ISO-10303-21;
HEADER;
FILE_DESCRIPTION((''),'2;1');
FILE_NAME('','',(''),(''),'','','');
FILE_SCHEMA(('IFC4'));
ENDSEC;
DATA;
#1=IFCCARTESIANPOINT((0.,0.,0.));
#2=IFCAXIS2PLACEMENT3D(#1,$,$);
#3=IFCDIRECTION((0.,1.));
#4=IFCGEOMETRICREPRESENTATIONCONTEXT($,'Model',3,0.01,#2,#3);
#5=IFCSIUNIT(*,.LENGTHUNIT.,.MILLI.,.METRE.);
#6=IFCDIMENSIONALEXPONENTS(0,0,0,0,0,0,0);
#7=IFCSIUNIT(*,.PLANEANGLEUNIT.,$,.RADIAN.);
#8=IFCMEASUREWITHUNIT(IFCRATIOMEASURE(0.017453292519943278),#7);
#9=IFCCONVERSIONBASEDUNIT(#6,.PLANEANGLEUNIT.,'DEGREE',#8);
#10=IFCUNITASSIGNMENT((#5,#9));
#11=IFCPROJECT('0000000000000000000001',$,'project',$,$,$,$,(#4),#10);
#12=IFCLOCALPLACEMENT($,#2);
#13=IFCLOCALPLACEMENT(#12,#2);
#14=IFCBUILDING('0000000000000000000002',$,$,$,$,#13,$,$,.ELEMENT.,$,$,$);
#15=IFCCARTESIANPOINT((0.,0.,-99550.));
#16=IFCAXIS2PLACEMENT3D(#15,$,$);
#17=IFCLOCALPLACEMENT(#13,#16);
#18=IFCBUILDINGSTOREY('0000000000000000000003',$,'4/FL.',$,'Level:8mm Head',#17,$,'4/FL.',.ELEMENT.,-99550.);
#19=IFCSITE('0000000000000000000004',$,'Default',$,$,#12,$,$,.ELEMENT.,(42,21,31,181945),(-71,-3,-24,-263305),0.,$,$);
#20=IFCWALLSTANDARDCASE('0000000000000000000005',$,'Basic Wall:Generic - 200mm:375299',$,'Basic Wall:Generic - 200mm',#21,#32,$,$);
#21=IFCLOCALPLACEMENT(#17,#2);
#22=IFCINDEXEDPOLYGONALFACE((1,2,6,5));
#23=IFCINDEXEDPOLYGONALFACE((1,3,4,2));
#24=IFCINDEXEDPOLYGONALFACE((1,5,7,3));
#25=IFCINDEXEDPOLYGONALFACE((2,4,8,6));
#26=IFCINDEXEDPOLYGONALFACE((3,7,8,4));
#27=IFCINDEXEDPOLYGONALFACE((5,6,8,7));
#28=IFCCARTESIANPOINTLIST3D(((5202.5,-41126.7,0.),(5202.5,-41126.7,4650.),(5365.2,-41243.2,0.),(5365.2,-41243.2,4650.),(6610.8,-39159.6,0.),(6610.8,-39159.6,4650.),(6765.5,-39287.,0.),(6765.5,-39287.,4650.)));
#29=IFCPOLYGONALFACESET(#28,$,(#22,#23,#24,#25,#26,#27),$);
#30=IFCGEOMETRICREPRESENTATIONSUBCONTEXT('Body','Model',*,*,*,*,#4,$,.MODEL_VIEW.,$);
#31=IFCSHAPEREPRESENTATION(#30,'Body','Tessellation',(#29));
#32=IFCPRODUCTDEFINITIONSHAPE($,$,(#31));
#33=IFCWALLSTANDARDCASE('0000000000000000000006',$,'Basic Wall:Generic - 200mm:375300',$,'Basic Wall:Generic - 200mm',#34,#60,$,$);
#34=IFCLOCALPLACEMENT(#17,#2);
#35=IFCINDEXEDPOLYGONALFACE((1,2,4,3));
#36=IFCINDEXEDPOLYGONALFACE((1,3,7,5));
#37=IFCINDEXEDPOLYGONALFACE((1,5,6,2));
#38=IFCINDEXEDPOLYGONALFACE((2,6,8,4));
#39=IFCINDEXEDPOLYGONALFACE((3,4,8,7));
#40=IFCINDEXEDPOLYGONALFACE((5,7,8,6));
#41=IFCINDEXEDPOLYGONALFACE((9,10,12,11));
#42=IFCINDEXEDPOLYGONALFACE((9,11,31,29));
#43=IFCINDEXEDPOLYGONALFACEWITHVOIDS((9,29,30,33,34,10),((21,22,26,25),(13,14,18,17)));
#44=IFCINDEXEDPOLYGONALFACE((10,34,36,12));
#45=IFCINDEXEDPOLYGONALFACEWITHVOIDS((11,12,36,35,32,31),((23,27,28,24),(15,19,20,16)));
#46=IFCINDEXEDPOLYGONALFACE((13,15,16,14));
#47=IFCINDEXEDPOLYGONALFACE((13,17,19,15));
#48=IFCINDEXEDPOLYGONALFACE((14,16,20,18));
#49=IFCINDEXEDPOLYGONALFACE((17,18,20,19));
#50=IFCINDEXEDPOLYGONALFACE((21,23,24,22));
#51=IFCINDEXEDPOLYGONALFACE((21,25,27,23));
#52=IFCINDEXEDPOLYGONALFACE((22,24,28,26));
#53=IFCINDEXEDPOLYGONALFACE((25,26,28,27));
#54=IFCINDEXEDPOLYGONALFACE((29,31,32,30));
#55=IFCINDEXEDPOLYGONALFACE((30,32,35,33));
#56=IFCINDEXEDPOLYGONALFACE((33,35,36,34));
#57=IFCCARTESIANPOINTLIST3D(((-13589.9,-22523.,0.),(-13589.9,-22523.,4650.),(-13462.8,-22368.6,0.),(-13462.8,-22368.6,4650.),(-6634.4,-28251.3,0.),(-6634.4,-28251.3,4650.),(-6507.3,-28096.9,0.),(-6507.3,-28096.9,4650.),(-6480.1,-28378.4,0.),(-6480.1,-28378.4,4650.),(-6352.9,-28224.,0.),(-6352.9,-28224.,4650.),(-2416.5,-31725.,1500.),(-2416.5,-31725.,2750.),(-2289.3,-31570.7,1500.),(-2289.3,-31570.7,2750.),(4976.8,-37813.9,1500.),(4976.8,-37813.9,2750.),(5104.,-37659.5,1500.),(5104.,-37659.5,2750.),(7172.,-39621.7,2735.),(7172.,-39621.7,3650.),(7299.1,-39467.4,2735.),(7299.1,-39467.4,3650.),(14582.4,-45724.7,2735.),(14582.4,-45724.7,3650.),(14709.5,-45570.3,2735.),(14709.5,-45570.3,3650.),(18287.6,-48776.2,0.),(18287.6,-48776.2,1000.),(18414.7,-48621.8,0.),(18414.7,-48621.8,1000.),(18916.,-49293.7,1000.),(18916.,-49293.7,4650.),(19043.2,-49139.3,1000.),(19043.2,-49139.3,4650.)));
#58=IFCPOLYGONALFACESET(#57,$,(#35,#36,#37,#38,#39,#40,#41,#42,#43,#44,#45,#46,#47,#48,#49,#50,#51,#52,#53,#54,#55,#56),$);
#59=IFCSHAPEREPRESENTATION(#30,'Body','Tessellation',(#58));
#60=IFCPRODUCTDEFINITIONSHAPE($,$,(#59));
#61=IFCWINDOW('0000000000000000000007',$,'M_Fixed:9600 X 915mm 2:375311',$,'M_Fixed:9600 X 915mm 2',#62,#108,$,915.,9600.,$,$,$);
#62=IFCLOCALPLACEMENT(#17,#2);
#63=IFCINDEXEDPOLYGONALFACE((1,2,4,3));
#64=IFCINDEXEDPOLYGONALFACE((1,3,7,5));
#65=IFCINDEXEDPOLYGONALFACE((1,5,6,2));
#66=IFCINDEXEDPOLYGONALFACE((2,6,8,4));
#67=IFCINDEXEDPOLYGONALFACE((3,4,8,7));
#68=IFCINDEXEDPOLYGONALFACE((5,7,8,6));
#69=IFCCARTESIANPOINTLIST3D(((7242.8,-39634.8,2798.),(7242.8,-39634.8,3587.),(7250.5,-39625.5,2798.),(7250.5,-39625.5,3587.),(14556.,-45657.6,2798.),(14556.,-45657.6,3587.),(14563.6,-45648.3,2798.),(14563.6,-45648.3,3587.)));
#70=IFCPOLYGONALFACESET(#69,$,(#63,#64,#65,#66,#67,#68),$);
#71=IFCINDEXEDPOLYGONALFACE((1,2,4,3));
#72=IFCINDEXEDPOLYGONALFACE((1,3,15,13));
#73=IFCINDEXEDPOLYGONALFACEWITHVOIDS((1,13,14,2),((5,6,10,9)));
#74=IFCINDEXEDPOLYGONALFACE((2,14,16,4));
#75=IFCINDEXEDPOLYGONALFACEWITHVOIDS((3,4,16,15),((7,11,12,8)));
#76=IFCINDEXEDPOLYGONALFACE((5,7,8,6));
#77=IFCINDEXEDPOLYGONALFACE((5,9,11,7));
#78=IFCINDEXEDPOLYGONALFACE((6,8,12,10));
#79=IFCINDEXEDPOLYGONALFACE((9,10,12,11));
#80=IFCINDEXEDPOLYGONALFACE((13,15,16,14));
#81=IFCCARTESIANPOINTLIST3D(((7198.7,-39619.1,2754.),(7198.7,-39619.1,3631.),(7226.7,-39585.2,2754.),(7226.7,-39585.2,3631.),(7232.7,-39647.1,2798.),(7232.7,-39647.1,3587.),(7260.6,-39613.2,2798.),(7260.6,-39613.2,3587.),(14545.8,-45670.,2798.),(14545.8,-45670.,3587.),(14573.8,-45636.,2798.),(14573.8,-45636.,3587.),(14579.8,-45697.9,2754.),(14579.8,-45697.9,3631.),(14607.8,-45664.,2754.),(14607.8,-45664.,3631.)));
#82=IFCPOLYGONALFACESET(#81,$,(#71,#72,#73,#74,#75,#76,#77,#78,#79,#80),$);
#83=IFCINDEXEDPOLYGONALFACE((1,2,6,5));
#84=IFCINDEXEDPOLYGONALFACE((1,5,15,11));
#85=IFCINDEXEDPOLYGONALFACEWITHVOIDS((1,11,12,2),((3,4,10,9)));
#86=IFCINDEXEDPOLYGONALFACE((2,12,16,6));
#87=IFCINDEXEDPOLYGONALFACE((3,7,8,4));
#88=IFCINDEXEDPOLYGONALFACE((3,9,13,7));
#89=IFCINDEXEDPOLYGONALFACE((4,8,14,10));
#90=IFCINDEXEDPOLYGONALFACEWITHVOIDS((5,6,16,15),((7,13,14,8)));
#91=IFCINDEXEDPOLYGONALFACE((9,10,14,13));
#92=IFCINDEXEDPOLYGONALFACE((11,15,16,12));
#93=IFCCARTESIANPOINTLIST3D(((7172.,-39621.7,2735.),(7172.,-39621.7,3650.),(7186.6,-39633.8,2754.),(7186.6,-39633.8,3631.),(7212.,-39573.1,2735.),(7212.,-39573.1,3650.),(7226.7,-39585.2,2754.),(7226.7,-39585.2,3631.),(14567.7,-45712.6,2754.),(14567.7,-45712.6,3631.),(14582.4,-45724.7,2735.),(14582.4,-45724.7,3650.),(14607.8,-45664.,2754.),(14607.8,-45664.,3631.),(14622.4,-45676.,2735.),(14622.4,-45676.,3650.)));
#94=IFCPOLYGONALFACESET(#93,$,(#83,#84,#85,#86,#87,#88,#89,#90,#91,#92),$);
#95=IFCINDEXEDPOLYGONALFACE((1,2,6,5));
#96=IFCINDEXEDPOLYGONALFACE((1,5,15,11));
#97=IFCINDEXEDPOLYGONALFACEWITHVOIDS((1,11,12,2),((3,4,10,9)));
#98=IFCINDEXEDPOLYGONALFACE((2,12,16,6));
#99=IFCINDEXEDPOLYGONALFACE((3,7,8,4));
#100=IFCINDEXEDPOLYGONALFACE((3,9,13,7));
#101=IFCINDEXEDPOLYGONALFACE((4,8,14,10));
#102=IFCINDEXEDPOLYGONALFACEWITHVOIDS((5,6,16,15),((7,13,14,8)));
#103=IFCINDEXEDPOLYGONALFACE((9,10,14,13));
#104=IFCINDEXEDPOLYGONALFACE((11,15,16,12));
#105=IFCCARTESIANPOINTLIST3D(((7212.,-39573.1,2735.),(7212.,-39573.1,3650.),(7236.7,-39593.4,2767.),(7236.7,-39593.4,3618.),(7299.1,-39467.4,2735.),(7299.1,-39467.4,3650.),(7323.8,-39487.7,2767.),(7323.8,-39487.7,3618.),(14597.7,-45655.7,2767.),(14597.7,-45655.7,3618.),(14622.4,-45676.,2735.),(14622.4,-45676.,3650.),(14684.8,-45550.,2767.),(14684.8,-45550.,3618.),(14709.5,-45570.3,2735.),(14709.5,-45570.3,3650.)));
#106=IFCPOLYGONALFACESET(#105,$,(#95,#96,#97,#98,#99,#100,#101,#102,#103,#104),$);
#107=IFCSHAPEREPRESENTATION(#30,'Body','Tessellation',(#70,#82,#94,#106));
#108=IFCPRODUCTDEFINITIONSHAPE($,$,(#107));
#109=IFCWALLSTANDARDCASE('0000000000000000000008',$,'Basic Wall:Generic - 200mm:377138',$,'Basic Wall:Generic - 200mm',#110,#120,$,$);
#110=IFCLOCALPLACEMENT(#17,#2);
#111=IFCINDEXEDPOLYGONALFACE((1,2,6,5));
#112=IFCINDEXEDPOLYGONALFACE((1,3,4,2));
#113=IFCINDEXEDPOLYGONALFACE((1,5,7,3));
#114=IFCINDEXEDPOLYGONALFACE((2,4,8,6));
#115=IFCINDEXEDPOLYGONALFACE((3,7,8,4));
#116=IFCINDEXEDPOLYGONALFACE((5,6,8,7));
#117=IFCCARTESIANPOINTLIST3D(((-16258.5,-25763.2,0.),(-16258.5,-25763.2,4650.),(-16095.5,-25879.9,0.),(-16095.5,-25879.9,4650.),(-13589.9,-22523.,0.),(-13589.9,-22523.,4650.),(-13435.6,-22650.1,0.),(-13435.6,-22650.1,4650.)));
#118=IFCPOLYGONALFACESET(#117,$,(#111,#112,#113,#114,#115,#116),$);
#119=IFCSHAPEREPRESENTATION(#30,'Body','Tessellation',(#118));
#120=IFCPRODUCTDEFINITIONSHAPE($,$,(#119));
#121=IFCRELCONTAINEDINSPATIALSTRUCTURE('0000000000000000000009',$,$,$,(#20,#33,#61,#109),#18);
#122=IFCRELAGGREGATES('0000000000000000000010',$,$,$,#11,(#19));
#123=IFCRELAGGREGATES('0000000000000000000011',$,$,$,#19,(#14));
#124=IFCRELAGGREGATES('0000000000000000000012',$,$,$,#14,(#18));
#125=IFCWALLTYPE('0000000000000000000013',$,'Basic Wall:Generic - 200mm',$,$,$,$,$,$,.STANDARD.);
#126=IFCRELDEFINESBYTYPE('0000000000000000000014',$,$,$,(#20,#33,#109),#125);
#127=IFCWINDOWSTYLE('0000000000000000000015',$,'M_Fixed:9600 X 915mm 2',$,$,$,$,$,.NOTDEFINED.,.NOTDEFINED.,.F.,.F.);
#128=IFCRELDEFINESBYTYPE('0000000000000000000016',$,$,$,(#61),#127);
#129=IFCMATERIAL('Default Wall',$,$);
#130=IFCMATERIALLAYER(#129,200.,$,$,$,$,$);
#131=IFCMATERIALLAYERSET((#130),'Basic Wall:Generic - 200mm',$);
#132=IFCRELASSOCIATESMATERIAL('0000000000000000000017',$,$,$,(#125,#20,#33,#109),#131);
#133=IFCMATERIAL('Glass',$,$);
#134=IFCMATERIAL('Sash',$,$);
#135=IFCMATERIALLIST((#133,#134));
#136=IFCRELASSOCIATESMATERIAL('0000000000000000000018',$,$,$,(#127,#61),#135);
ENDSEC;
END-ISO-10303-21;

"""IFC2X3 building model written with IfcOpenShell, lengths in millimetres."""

from ifc_helpers import new_model, entity, si_unit, converted_unit, direction, frame, frame_2d, origin, place, context, subcontext, project, spatial, polyline, rectangle, outline, extrude, source, transform, mapped, material, material_list, layer, layer_set, layer_usage, type_object, type_shapes, element, fill, save


model = new_model("IFC2X3")

# Units and contexts
model_context = context("Model", 3, precision=0.01, world=origin(), true_north=direction((0.0, 1.0)))
body_context = subcontext(model_context, "Body", "Model", "MODEL_VIEW")
ifc_project = project(units=[si_unit("LENGTHUNIT", "METRE", prefix="MILLI"), converted_unit("PLANEANGLEUNIT", "DEGREE", entity("IfcRatioMeasure", 0.017453292519943278), si_unit("PLANEANGLEUNIT", "RADIAN"), dimensions=[0, 0, 0, 0, 0, 0, 0])], contexts=[model_context])

# Site, building, storey
site_placement = place(None, origin())
site = spatial("IfcSite", under=ifc_project, at=site_placement, Name="Default", CompositionType="ELEMENT", RefLatitude=(42, 21, 31, 181945), RefLongitude=(-71, -3, -24, -263305), RefElevation=0.0)
building_placement = place(site_placement, origin())
building = spatial("IfcBuilding", under=site, at=building_placement, CompositionType="ELEMENT")
storey_placement = place(building_placement, frame((0.0, 0.0, -99550.0)))
storey = spatial("IfcBuildingStorey", under=building, at=storey_placement, Name="4/FL.", ObjectType="Level:8mm Head", LongName="4/FL.", CompositionType="ELEMENT", Elevation=-99550.0)

# Shared definitions
ifc_material_1 = material(Name="Default Wall")
ifc_layer = layer(ifc_material_1, 200.0)
ifc_layer_set = layer_set([ifc_layer], Name="Basic Wall:Generic - 200mm")
ifc_layer_usage = layer_usage(ifc_layer_set, "AXIS2", "NEGATIVE", 100.0)
wall_type = type_object("IfcWallType", Name="Basic Wall:Generic - 200mm", PredefinedType="STANDARD", material=ifc_layer_set)

# Shared definitions
ifc_material_2 = material(Name="Glass")
ifc_material_3 = material(Name="Sash")
ifc_material_list = material_list([ifc_material_2, ifc_material_3])

# Wall
wall_1_placement = place(storey_placement, frame((5283.8, -41185.0, 0.0), z_axis=(0.0, 0.0, 1.0), x_axis=(0.582098, 0.813119, 0.0)))
element("IfcWallStandardCase", 1, at=wall_1_placement, inside=storey, type_object=wall_type, material=ifc_layer_usage, Name="Basic Wall:Generic - 200mm:375299", ObjectType="Basic Wall:Generic - 200mm", context=body_context, shape_type="SweptSolid", body=[
    extrude(outline(polyline([(2405.7, -100.0), (2419.3, 100.0), (0.0, 100.0), (0.0, -100.0), (2405.7, -100.0)])), origin(), (0.0, 0.0, 1.0), 4650.0),
])

# Wall, openings, window
wall_2_placement = place(storey_placement, frame((-13526.4, -22445.8, 0.0), z_axis=(0.0, 0.0, 1.0), x_axis=(0.771917, -0.635723, 0.0)))
wall_2 = element("IfcWallStandardCase", 2, at=wall_2_placement, inside=storey, type_object=wall_type, material=ifc_layer_usage, Name="Basic Wall:Generic - 200mm:375300", ObjectType="Basic Wall:Generic - 200mm", context=body_context, shape_type="SweptSolid", body=[
    extrude(rectangle(XDim=42110.7, YDim=200.0, at=frame_2d((21055.3, 0.0), x_axis=(-1.0, 0.0))), origin(), (0.0, 0.0, 1.0), 4650.0),
])
opening_1_placement = place(storey_placement, frame((-13526.4, -22445.8, 0.0), z_axis=(0.0, 0.0, 1.0), x_axis=(0.771917, -0.635723, 0.0)))
element("IfcOpeningElement", 3, at=opening_1_placement, cuts=wall_2, ObjectType="Opening", context=body_context, shape_type="SweptSolid", body=[
    extrude(rectangle(XDim=4650.0, YDim=200.0, at=frame_2d((0.0, 0.0), x_axis=(1.0, 0.0))), frame((9010.7, 0.0, 2325.0), z_axis=(1.0, 0.0, 0.0), x_axis=(0.0, 0.0, -1.0)), (0.0, 0.0, 1.0), 200.0),
])
opening_2_placement = place(wall_2_placement, origin())
element("IfcOpeningElement", 4, at=opening_2_placement, cuts=wall_2, ObjectType="Opening", context=body_context, shape_type="SweptSolid", body=[
    extrude(rectangle(XDim=1250.0, YDim=9577.8, at=frame_2d((0.0, 0.0), x_axis=(1.0, 0.0))), frame((19263.9, -100.0, 2125.0), z_axis=(0.0, 1.0, 0.0), x_axis=(0.0, 0.0, -1.0)), (0.0, 0.0, 1.0), 200.0),
])
opening_3_placement = place(wall_2_placement, frame((-3828.1, 25925.3, 0.0), z_axis=(0.0, 0.0, 1.0), x_axis=(0.771917, 0.635723, 0.0)))
element("IfcOpeningElement", 5, at=opening_3_placement, cuts=wall_2, ObjectType="Opening", context=body_context, shape_type="SweptSolid", body=[
    extrude(rectangle(XDim=1000.0, YDim=1010.1, at=frame_2d((0.0, 0.0), x_axis=(1.0, 0.0))), frame((18669.4, -49107.0, 500.0), z_axis=(0.635723, 0.771917, 0.0), x_axis=(0.0, 0.0, -1.0)), (0.0, 0.0, 1.0), 1012.7),
])
opening_4_placement = place(wall_2_placement, frame((36496.6, 100.0, 2735.0)))
opening_4 = element("IfcOpeningElement", 6, at=opening_4_placement, cuts=wall_2, ObjectType="Opening", context=body_context, shape_type="SweptSolid", body=[
    extrude(rectangle(XDim=915.0, YDim=9600.0, at=frame_2d((457.5, 4800.0), x_axis=(1.0, 0.0))), frame((0.0, 0.0, 0.0), z_axis=(0.0, -1.0, 0.0), x_axis=(0.0, 0.0, 1.0)), (0.0, 0.0, 1.0), 200.0),
])
window_style_1 = type_object("IfcWindowStyle", Name="M_Fixed:9600 X 915mm 2", ConstructionType="NOTDEFINED", OperationType="NOTDEFINED", ParameterTakesPrecedence=False, Sizeable=False, material=ifc_material_list)
shared_shape_1 = source(origin(), body_context, "Body", "SweptSolid", [
    extrude(rectangle(XDim=12.0, YDim=9474.0, at=frame_2d((0.0, 0.0), x_axis=(1.0, 0.0))), frame((4800.0, 159.0, 63.0), z_axis=(0.0, 0.0, 1.0), x_axis=(0.0, -1.0, 0.0)), (0.0, 0.0, 1.0), 789.0),
    extrude(outline(polyline([(-4781.0, -438.5), (4781.0, -438.5), (4781.0, 438.5), (-4781.0, 438.5), (-4781.0, -438.5)]), holes=[polyline([(-4737.0, -394.5), (-4737.0, 394.5), (4737.0, 394.5), (4737.0, -394.5), (-4737.0, -394.5)])]), frame((4800.0, 137.0, 457.5), z_axis=(0.0, 1.0, 0.0), x_axis=(1.0, 0.0, 0.0)), (0.0, 0.0, 1.0), 44.0),
    extrude(outline(polyline([(-4800.0, -457.5), (4800.0, -457.5), (4800.0, 457.5), (-4800.0, 457.5), (-4800.0, -457.5)]), holes=[polyline([(-4781.0, -438.5), (-4781.0, 438.5), (4781.0, 438.5), (4781.0, -438.5), (-4781.0, -438.5)])]), frame((4800.0, 137.0, 457.5), z_axis=(0.0, 1.0, 0.0), x_axis=(1.0, 0.0, 0.0)), (0.0, 0.0, 1.0), 63.0),
    extrude(outline(polyline([(-4800.0, -457.5), (4800.0, -457.5), (4800.0, 457.5), (-4800.0, 457.5), (-4800.0, -457.5)]), holes=[polyline([(-4768.0, -425.5), (-4768.0, 425.5), (4768.0, 425.5), (4768.0, -425.5), (-4768.0, -425.5)])]), frame((4800.0, 0.0, 457.5), z_axis=(0.0, 1.0, 0.0), x_axis=(1.0, 0.0, 0.0)), (0.0, 0.0, 1.0), 137.0),
])
type_shapes(window_style_1, [shared_shape_1])
window_1_placement = place(opening_4_placement, frame((0.0, 0.0, 0.0), z_axis=(0.0, 0.0, 1.0), x_axis=(-1.0, 0.0, 0.0)))
window_1 = element("IfcWindow", 7, at=window_1_placement, inside=storey, type_object=window_style_1, material=ifc_material_list, Name="M_Fixed:9600 X 915mm 2:375311", ObjectType="M_Fixed:9600 X 915mm 2", OverallHeight=915.0, OverallWidth=9600.0, context=body_context, shape_type="MappedRepresentation", body=[
    mapped(shared_shape_1, transform((0.0, 0.0, 0.0), scale=1.0)),
])
fill(opening_4, window_1)

# Wall
wall_3_placement = place(storey_placement, frame((-16181.3, -25826.7, 0.0), z_axis=(0.0, 0.0, 1.0), x_axis=(0.635723, 0.771917, 0.0)))
element("IfcWallStandardCase", 8, at=wall_3_placement, inside=storey, type_object=wall_type, material=ifc_layer_usage, Name="Basic Wall:Generic - 200mm:377138", ObjectType="Basic Wall:Generic - 200mm", context=body_context, shape_type="SweptSolid", body=[
    extrude(outline(polyline([(4197.6, -100.0), (4197.6, 100.0), (0.0, 100.0), (13.5, -100.0), (4197.6, -100.0)])), origin(), (0.0, 0.0, 1.0), 4650.0),
])

save(model, "model.ifc")
